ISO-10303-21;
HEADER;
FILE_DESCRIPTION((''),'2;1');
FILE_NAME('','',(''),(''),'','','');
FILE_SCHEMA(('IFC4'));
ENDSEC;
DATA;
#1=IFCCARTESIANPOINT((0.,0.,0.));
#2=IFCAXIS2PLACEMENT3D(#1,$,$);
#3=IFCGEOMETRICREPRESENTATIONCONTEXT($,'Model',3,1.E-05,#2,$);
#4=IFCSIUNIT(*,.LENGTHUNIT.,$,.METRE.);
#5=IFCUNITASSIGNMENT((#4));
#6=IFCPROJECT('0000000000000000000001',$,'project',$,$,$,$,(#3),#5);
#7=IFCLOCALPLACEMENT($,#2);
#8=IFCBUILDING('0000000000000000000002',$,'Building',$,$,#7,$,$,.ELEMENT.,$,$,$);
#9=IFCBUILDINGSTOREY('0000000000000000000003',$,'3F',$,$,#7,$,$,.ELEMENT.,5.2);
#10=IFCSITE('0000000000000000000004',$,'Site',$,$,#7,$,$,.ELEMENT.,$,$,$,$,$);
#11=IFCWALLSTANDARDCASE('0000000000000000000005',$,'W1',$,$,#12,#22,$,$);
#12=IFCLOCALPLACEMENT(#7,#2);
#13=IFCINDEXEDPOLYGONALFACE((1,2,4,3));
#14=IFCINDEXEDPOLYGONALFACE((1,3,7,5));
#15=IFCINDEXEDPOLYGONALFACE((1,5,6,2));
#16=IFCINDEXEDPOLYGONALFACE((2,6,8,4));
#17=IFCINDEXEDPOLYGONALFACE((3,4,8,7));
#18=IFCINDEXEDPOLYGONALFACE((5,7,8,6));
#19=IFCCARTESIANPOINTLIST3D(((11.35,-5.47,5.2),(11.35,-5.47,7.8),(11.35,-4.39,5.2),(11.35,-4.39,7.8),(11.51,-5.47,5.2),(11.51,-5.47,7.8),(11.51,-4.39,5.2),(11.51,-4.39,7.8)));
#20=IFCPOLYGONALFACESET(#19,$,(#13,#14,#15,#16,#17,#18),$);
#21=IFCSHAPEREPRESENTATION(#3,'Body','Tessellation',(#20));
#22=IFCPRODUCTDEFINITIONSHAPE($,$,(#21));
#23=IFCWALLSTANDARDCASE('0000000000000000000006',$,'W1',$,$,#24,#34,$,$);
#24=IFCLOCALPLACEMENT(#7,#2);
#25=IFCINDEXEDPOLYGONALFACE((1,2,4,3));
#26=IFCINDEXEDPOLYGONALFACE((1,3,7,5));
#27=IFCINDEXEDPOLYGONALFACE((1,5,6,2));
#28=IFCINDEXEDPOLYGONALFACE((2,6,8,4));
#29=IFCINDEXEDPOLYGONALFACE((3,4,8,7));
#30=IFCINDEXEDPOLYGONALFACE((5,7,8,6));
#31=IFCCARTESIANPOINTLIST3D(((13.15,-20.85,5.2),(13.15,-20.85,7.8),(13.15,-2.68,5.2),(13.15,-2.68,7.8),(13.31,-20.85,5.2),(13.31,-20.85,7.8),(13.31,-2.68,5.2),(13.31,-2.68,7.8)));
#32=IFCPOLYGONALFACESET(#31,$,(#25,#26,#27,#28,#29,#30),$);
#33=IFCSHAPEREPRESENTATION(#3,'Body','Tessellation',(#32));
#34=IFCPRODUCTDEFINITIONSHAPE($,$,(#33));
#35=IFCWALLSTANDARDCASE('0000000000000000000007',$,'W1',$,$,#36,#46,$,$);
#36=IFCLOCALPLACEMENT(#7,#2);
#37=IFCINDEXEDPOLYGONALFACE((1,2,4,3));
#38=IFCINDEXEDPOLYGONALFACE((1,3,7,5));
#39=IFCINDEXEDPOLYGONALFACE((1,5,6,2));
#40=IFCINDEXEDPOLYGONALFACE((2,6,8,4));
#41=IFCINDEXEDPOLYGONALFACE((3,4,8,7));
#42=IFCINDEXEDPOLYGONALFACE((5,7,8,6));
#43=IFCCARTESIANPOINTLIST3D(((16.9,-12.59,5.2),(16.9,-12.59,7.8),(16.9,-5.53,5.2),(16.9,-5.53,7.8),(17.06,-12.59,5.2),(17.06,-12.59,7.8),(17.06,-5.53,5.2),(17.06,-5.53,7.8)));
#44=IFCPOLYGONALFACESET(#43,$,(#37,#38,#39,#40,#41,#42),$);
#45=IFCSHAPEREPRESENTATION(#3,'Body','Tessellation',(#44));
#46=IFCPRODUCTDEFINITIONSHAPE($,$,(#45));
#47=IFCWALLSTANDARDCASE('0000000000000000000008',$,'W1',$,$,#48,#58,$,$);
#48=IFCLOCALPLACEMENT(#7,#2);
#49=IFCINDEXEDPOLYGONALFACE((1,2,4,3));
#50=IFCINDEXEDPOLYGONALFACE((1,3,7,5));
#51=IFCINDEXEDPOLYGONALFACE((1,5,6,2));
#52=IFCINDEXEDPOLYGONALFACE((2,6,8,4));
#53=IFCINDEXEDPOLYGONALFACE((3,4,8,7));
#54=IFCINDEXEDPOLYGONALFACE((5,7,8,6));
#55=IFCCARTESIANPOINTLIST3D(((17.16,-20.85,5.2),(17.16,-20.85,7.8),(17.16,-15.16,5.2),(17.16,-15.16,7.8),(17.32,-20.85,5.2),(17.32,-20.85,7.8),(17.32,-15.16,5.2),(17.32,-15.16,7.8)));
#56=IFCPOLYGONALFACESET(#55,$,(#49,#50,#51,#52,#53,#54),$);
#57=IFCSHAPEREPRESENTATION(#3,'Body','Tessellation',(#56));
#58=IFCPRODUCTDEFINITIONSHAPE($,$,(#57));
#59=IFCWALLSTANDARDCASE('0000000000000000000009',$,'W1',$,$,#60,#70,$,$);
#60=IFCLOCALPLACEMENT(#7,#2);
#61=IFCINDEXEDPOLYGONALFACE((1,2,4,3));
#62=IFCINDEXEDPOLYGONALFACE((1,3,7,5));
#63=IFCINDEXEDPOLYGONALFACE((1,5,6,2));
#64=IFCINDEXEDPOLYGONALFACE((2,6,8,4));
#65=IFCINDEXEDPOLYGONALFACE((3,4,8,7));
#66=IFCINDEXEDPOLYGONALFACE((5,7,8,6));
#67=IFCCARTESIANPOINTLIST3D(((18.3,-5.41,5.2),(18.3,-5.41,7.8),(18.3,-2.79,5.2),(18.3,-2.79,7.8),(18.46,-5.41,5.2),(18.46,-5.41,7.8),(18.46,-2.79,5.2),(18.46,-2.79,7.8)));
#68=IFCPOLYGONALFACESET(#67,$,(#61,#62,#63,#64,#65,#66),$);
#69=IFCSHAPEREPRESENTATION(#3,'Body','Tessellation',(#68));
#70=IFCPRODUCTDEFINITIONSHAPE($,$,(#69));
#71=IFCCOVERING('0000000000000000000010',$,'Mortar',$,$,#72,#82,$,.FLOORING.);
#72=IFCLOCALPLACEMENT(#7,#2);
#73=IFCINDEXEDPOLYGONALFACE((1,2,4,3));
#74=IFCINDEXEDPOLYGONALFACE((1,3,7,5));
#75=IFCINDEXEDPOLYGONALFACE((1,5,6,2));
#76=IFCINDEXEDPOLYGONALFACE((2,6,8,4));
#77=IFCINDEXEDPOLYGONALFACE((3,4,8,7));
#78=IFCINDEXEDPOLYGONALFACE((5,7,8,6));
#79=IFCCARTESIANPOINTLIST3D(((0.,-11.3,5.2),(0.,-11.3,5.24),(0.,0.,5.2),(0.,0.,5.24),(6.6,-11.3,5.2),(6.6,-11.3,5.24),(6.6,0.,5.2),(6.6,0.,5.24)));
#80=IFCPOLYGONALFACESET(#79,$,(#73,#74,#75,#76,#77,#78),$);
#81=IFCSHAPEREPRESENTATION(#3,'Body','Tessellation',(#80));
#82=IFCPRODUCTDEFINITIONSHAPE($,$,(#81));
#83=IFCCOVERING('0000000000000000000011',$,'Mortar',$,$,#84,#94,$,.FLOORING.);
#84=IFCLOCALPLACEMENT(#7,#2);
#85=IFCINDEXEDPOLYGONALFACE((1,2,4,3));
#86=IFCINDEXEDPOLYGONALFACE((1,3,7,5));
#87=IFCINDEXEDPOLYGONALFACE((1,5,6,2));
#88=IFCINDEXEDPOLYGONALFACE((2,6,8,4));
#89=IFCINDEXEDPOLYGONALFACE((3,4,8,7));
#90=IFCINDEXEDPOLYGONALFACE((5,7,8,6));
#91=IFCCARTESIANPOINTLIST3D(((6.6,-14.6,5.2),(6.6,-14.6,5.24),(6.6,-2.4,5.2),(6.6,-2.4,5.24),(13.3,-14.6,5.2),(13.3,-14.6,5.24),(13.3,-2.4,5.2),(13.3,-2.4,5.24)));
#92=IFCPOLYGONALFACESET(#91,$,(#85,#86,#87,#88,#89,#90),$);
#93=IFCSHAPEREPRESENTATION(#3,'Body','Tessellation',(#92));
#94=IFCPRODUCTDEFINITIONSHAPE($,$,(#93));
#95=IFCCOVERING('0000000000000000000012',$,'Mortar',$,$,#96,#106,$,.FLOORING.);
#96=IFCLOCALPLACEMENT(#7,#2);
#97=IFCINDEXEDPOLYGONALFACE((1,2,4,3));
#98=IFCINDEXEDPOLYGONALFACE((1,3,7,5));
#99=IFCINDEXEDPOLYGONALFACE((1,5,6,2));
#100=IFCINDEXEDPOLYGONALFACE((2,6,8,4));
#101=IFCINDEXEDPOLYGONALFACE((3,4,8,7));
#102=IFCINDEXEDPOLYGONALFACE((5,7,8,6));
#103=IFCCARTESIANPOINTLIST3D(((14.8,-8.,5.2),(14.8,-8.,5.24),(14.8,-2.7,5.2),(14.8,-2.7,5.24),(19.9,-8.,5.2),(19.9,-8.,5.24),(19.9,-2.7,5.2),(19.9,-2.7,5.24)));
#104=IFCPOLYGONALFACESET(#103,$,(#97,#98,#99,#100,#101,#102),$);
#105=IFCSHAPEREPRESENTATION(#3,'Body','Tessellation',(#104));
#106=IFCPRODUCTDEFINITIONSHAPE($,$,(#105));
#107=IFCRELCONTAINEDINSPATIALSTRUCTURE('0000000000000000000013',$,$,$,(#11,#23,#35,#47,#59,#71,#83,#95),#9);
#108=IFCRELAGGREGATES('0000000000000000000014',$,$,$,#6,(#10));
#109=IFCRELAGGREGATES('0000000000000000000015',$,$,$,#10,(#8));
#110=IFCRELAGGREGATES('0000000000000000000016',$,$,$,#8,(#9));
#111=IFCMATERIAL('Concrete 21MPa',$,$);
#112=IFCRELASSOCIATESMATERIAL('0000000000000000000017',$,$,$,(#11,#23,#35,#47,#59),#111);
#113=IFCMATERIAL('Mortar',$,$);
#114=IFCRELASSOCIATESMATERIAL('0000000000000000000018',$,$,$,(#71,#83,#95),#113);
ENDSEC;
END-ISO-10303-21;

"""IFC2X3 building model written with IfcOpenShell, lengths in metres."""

from ifc_helpers import new_model, si_unit, frame, origin, origin_2d, place, context, project, spatial, rectangle, extrude, material, element, save


model = new_model("IFC2X3")

# Units and contexts
model_context = context("Model", 3, precision=1e-05, world=origin())
ifc_project = project(units=[si_unit("LENGTHUNIT", "METRE")], contexts=[model_context])

# Site, building, storey
placement = place(None, origin())
site = spatial("IfcSite", under=ifc_project, at=placement, Name="Site", CompositionType="ELEMENT")
building = spatial("IfcBuilding", under=site, at=placement, Name="Building", CompositionType="ELEMENT")
storey = spatial("IfcBuildingStorey", under=building, at=placement, Name="3F", CompositionType="ELEMENT", Elevation=5.2)

# Shared definitions
ifc_material_1 = material(Name="Concrete 21MPa")

# Walls
wall_1_placement = place(None, frame((11.43, -4.93, 5.2)))
element("IfcWallStandardCase", 1, at=wall_1_placement, inside=storey, material=ifc_material_1, Name="W1", context=model_context, shape_type="SweptSolid", body=[
    extrude(rectangle(XDim=0.16, YDim=1.08, at=origin_2d()), origin(), (0.0, 0.0, 1.0), 2.6),
])
wall_2_placement = place(None, frame((13.23, -11.765, 5.2)))
element("IfcWallStandardCase", 2, at=wall_2_placement, inside=storey, material=ifc_material_1, Name="W1", context=model_context, shape_type="SweptSolid", body=[
    extrude(rectangle(XDim=0.16, YDim=18.17, at=origin_2d()), origin(), (0.0, 0.0, 1.0), 2.6),
])
wall_3_placement = place(None, frame((16.98, -9.06, 5.2)))
element("IfcWallStandardCase", 3, at=wall_3_placement, inside=storey, material=ifc_material_1, Name="W1", context=model_context, shape_type="SweptSolid", body=[
    extrude(rectangle(XDim=0.16, YDim=7.06, at=origin_2d()), origin(), (0.0, 0.0, 1.0), 2.6),
])
wall_4_placement = place(None, frame((17.24, -18.005, 5.2)))
element("IfcWallStandardCase", 4, at=wall_4_placement, inside=storey, material=ifc_material_1, Name="W1", context=model_context, shape_type="SweptSolid", body=[
    extrude(rectangle(XDim=0.16, YDim=5.69, at=origin_2d()), origin(), (0.0, 0.0, 1.0), 2.6),
])
wall_5_placement = place(None, frame((18.38, -4.1, 5.2)))
element("IfcWallStandardCase", 5, at=wall_5_placement, inside=storey, material=ifc_material_1, Name="W1", context=model_context, shape_type="SweptSolid", body=[
    extrude(rectangle(XDim=0.16, YDim=2.62, at=origin_2d()), origin(), (0.0, 0.0, 1.0), 2.6),
])

# Coverings
ifc_material_2 = material(Name="Mortar")
covering_1_placement = place(None, frame((3.3, -5.65, 5.2)))
element("IfcCovering", 6, at=covering_1_placement, inside=storey, material=ifc_material_2, Name="Mortar", PredefinedType="FLOORING", context=model_context, shape_type="SweptSolid", body=[
    extrude(rectangle(XDim=6.6, YDim=11.3, at=origin_2d()), origin(), (0.0, 0.0, 1.0), 0.04),
])
covering_2_placement = place(None, frame((9.95, -8.5, 5.2)))
element("IfcCovering", 7, at=covering_2_placement, inside=storey, material=ifc_material_2, Name="Mortar", PredefinedType="FLOORING", context=model_context, shape_type="SweptSolid", body=[
    extrude(rectangle(XDim=6.7, YDim=12.2, at=origin_2d()), origin(), (0.0, 0.0, 1.0), 0.04),
])
covering_3_placement = place(None, frame((17.35, -5.35, 5.2)))
element("IfcCovering", 8, at=covering_3_placement, inside=storey, material=ifc_material_2, Name="Mortar", PredefinedType="FLOORING", context=model_context, shape_type="SweptSolid", body=[
    extrude(rectangle(XDim=5.1, YDim=5.3, at=origin_2d()), origin(), (0.0, 0.0, 1.0), 0.04),
])

save(model, "model.ifc")
